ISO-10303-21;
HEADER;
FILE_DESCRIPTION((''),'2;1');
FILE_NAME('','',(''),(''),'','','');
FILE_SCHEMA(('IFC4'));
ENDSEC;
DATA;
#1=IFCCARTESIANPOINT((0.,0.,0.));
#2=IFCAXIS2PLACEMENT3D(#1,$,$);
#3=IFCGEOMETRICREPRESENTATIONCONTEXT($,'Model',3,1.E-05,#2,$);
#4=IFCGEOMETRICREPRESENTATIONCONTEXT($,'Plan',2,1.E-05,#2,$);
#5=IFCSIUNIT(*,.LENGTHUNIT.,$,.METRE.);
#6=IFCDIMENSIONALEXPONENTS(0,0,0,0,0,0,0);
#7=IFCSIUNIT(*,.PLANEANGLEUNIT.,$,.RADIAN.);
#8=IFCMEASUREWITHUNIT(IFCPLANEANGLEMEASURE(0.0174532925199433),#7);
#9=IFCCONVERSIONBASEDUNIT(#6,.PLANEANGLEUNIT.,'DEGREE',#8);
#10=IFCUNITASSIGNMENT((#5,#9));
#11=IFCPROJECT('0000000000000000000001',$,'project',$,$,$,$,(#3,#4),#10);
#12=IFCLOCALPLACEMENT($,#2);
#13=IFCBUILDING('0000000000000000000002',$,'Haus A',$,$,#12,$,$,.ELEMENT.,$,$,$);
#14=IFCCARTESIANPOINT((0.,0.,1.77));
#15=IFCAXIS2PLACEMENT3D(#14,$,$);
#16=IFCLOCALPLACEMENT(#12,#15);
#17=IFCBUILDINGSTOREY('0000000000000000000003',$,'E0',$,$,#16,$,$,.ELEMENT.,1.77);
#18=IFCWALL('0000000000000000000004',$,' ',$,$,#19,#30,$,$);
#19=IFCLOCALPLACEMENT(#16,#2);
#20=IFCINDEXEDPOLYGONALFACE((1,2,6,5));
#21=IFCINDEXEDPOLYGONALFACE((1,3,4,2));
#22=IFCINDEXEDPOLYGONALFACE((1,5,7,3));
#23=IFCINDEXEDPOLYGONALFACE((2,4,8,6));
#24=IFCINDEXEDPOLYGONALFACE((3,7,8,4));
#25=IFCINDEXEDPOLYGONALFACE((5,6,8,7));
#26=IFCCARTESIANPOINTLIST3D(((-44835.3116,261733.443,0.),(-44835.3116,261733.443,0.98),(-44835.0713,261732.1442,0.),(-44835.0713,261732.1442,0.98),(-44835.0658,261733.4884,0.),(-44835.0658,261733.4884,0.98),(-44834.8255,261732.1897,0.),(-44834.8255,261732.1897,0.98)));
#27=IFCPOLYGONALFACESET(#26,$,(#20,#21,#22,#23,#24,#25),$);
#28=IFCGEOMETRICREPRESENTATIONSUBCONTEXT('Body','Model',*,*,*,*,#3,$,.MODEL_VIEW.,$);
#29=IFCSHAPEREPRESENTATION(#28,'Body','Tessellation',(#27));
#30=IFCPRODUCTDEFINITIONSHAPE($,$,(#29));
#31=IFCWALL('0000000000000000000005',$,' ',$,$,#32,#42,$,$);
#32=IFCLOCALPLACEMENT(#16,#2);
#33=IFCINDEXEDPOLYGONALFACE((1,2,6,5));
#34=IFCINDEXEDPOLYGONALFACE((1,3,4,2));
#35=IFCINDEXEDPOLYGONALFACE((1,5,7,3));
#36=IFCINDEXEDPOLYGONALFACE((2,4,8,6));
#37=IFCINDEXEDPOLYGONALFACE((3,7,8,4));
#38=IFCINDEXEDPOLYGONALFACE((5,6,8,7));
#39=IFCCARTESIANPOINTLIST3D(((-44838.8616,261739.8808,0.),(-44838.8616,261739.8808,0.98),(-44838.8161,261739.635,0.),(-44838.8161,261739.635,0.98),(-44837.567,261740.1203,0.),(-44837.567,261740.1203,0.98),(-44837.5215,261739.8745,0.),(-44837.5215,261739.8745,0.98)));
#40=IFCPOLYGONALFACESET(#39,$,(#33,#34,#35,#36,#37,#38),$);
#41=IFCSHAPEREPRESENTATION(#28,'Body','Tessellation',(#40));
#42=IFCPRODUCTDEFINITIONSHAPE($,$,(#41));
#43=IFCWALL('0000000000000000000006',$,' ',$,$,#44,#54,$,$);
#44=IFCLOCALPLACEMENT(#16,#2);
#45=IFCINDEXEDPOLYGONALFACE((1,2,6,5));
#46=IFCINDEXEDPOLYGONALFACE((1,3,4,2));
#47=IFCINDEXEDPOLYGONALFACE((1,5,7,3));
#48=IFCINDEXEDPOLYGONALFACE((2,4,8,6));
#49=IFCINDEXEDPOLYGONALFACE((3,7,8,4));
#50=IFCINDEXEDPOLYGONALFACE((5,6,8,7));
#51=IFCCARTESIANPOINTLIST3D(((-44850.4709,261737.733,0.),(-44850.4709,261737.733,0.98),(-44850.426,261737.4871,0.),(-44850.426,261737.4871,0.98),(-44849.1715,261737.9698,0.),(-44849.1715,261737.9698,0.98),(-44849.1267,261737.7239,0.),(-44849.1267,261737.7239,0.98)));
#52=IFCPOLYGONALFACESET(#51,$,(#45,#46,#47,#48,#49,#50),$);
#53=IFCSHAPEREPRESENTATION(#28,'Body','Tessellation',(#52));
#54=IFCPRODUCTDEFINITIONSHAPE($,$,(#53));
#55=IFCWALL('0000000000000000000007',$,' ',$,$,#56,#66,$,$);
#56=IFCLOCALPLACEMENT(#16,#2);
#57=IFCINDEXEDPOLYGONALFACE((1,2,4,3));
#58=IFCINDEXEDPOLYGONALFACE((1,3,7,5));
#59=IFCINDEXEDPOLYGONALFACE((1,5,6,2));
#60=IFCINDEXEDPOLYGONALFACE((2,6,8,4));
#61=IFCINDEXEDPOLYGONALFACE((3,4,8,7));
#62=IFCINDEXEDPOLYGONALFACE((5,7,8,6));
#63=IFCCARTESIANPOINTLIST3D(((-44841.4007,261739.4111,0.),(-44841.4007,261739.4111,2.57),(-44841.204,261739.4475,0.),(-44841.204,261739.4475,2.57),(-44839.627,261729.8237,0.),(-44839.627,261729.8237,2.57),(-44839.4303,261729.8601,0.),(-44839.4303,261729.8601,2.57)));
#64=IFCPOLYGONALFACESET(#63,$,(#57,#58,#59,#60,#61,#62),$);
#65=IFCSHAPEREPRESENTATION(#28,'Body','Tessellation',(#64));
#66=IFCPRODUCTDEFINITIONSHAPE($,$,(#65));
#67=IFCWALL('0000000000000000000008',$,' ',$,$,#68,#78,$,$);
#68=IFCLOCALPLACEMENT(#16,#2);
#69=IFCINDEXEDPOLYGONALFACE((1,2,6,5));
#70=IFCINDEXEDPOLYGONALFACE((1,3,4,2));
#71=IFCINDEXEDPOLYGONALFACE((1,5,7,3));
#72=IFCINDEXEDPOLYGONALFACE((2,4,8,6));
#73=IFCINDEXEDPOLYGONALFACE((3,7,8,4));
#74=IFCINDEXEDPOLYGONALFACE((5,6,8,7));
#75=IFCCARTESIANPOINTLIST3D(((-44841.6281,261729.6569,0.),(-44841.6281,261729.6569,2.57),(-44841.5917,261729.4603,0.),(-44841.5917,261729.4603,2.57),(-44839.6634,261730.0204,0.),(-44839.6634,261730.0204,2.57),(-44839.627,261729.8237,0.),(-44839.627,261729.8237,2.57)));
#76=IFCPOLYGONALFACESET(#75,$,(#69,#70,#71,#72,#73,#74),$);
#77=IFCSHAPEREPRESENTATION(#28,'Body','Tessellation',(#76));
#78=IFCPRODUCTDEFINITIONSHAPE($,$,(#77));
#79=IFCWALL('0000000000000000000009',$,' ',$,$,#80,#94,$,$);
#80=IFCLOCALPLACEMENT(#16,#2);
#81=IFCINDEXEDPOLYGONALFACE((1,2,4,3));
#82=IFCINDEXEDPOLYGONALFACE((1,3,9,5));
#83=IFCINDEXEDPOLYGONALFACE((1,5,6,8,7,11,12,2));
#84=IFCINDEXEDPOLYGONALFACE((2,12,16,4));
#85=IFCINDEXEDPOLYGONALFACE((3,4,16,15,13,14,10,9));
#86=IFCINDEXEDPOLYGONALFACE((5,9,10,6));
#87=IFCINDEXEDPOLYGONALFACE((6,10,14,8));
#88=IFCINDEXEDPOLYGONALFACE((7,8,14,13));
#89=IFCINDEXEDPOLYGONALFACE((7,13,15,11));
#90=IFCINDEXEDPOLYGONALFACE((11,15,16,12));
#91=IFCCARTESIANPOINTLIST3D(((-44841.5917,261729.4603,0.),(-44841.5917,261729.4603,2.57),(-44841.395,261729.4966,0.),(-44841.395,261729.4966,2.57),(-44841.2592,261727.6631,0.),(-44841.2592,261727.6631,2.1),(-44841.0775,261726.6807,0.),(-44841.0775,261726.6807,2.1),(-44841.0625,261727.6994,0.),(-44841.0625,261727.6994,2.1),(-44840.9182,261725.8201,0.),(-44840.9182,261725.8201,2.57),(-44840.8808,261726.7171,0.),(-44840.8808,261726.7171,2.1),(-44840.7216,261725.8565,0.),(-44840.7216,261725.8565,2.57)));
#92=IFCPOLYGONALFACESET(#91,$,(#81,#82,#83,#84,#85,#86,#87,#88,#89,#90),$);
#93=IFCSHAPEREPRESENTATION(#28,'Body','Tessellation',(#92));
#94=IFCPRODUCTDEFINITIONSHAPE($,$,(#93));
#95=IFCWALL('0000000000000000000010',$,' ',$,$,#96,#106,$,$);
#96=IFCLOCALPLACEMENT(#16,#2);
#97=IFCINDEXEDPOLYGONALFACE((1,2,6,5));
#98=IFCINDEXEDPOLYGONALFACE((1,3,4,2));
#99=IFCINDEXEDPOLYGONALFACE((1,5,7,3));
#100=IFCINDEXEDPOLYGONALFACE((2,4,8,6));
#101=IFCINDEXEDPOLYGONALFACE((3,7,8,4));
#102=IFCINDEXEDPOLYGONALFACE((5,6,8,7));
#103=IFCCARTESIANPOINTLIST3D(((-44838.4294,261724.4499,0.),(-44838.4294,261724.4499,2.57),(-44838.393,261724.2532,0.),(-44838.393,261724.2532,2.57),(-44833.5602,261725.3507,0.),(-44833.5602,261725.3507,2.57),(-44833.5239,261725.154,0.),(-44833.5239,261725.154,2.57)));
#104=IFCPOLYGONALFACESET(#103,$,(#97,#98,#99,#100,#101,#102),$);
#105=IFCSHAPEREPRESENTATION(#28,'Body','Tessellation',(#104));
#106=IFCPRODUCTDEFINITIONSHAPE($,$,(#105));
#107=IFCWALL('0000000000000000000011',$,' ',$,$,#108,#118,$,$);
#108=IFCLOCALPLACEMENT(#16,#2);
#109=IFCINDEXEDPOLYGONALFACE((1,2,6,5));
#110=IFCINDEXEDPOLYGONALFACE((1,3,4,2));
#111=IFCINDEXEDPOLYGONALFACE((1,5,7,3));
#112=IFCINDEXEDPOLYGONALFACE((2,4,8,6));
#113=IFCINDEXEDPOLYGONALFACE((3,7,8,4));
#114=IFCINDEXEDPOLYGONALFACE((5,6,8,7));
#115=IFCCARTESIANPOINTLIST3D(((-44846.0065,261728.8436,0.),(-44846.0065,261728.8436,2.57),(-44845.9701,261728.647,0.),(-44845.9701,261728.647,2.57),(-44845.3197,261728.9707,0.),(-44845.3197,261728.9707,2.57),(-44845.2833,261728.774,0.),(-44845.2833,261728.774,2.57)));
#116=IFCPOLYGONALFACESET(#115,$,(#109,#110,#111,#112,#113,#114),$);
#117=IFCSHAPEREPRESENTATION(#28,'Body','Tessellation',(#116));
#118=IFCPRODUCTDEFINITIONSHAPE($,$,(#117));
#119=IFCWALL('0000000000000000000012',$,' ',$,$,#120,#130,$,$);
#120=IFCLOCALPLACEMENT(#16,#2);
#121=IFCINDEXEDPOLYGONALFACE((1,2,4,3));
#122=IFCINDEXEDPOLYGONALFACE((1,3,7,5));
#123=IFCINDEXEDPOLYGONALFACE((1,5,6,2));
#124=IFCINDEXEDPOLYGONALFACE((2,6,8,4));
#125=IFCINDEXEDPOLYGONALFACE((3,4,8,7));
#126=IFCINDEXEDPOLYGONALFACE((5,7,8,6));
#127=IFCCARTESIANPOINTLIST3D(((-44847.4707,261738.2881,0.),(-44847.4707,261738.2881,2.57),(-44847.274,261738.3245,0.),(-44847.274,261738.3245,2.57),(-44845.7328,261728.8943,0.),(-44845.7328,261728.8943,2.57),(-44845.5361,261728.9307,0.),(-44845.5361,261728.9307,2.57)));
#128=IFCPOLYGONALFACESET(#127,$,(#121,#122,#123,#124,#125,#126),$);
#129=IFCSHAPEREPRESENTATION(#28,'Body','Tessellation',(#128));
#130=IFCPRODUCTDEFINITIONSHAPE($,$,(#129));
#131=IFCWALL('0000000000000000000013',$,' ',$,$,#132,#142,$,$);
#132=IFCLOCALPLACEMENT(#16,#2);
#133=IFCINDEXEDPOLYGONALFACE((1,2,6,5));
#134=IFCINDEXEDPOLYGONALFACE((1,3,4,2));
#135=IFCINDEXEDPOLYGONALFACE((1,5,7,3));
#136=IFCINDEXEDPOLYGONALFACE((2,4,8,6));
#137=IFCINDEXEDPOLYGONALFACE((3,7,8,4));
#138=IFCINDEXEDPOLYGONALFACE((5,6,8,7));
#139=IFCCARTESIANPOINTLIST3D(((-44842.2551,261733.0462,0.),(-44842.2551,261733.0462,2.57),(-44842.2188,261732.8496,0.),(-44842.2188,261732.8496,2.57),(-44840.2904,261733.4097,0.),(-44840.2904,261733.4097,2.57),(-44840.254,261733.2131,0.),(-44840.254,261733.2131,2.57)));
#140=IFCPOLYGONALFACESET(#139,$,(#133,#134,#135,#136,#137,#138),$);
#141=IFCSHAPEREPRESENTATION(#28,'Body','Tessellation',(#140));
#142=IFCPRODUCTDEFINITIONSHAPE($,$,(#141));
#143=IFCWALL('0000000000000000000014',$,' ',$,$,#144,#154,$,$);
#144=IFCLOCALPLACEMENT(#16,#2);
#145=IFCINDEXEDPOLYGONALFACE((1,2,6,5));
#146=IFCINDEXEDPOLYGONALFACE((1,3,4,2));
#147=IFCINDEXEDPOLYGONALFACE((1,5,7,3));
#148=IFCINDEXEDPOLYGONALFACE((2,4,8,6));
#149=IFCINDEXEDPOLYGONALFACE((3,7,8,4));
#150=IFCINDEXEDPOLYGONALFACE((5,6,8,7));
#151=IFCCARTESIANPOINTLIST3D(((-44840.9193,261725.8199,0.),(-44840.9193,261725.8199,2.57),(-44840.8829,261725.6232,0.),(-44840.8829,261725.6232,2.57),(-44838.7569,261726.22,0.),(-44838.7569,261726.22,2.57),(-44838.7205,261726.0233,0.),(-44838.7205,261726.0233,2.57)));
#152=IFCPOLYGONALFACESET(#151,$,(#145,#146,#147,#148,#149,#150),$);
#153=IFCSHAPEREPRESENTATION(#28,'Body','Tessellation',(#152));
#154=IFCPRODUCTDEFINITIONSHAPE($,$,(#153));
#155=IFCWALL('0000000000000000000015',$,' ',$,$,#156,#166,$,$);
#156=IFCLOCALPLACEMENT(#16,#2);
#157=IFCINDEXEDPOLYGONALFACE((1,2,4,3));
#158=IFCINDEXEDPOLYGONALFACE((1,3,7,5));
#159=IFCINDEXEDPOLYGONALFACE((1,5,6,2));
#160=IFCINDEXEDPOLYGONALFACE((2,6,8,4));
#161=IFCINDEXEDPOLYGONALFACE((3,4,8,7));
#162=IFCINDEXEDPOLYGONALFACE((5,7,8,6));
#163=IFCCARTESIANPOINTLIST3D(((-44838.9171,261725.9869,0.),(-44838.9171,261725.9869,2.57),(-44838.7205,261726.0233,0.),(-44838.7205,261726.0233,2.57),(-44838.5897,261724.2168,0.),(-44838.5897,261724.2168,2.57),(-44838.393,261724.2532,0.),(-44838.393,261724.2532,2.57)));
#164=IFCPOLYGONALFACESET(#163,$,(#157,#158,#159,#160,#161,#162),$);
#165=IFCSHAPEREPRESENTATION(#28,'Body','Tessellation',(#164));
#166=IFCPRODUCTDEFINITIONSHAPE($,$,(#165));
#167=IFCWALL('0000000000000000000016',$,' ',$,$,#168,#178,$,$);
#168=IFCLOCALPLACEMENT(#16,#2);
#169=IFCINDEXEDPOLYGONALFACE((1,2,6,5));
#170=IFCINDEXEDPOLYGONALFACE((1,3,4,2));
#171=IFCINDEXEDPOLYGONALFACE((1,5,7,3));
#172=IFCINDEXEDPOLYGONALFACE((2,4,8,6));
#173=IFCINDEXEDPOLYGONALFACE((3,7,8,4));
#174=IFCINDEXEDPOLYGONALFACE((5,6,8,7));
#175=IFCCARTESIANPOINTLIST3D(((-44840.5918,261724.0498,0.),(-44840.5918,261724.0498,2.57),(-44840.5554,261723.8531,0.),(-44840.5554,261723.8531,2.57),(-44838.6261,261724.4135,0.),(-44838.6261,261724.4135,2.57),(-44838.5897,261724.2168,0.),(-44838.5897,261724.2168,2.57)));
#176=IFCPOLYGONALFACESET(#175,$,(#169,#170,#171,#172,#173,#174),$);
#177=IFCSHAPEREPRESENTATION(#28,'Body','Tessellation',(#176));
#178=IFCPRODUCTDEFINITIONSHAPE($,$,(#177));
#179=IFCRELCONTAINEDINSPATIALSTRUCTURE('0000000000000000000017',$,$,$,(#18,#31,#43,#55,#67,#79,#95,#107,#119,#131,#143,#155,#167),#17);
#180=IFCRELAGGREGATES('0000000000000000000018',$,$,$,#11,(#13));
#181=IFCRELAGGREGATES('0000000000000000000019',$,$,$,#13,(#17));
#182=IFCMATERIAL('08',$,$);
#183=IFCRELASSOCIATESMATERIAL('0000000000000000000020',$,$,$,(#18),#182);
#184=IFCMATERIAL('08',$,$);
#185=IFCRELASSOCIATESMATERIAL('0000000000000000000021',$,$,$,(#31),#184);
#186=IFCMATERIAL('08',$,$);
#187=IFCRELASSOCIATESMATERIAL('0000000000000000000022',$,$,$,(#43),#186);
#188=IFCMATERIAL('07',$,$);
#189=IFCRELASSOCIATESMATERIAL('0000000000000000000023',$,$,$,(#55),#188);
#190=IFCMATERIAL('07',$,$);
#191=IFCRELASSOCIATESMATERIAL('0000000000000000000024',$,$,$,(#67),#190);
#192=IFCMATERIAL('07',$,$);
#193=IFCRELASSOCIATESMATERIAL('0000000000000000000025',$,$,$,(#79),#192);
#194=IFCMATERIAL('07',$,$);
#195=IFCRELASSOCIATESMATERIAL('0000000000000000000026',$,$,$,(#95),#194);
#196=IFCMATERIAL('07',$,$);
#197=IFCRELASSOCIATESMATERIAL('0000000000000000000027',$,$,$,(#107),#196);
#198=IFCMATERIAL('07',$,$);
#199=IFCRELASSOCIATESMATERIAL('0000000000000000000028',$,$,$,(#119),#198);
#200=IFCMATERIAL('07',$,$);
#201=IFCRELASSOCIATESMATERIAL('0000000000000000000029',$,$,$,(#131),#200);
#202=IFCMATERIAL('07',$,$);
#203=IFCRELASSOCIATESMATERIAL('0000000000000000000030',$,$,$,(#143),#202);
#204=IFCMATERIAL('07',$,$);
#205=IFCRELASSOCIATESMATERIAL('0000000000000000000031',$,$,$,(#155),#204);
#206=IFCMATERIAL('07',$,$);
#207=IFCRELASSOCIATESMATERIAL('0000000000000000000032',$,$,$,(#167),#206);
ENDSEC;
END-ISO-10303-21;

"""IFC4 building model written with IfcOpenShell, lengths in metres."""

from ifc_helpers import new_model, entity, si_unit, converted_unit, frame, frame_2d, origin, origin_with_axes, place, context, subcontext, project, spatial, polyline, rectangle, outline, extrude, material, element, save


model = new_model("IFC4")

# Units and contexts
model_context = context("Model", 3, precision=1e-05, world=origin())
plan_context = context("Plan", 2, precision=1e-05, world=origin())
body_context = subcontext(model_context, "Body", "Model", "MODEL_VIEW")
ifc_project = project(units=[si_unit("LENGTHUNIT", "METRE"), converted_unit("PLANEANGLEUNIT", "DEGREE", entity("IfcPlaneAngleMeasure", 0.0174532925199433), si_unit("PLANEANGLEUNIT", "RADIAN"), dimensions=[0, 0, 0, 0, 0, 0, 0])], contexts=[model_context, plan_context])

# Building, storey
building_placement = place(None, origin())
building = spatial("IfcBuilding", under=ifc_project, at=building_placement, Name="Haus A", CompositionType="ELEMENT")
storey_placement = place(building_placement, frame((0.0, 0.0, 1.77)))
storey = spatial("IfcBuildingStorey", under=building, at=storey_placement, Name="E0", CompositionType="ELEMENT", Elevation=1.77)

# Walls
ifc_material_1 = material(Name="08")
wall_1_placement = place(storey_placement, frame((-44834.8255, 261732.1897, 0.0), z_axis=(0.0, 0.0, 1.0), x_axis=(-0.18192, 0.983313, 0.0)))
element("IfcWall", 1, at=wall_1_placement, inside=storey, material=ifc_material_1, Name=" ", context=body_context, shape_type="SweptSolid", body=[
    extrude(rectangle(XDim=1.3207, YDim=0.25, at=frame_2d((0.6604, 0.125), x_axis=(1.0, 0.0))), origin_with_axes(), (0.0, 0.0, 1.0), 0.98),
])
ifc_material_2 = material(Name="08")
wall_2_placement = place(storey_placement, frame((-44837.567, 261740.1203, 0.0), z_axis=(0.0, 0.0, 1.0), x_axis=(-0.983313, -0.18192, 0.0)))
element("IfcWall", 2, at=wall_2_placement, inside=storey, material=ifc_material_2, Name=" ", context=body_context, shape_type="SweptSolid", body=[
    extrude(rectangle(XDim=1.3165, YDim=0.25, at=frame_2d((0.6583, 0.125), x_axis=(1.0, 0.0))), origin_with_axes(), (0.0, 0.0, 1.0), 0.98),
])
ifc_material_3 = material(Name="08")
wall_3_placement = place(storey_placement, frame((-44849.1715, 261737.9698, 0.0), z_axis=(0.0, 0.0, 1.0), x_axis=(-0.983796, -0.17929, 0.0)))
element("IfcWall", 3, at=wall_3_placement, inside=storey, material=ifc_material_3, Name=" ", context=body_context, shape_type="SweptSolid", body=[
    extrude(rectangle(XDim=1.3208, YDim=0.25, at=frame_2d((0.6604, 0.125), x_axis=(1.0, 0.0))), origin_with_axes(), (0.0, 0.0, 1.0), 0.98),
])
ifc_material_4 = material(Name="07")
wall_4_placement = place(storey_placement, frame((-44841.4007, 261739.4111, 0.0), z_axis=(0.0, 0.0, 1.0), x_axis=(0.18192, -0.983313, 0.0)))
element("IfcWall", 4, at=wall_4_placement, inside=storey, material=ifc_material_4, Name=" ", context=body_context, shape_type="SweptSolid", body=[
    extrude(rectangle(XDim=9.75, YDim=0.2, at=frame_2d((4.875, 0.1), x_axis=(1.0, 0.0))), origin_with_axes(), (0.0, 0.0, 1.0), 2.57),
])
ifc_material_5 = material(Name="07")
wall_5_placement = place(storey_placement, frame((-44839.6634, 261730.0204, 0.0), z_axis=(0.0, 0.0, 1.0), x_axis=(-0.983313, -0.18192, 0.0)))
element("IfcWall", 5, at=wall_5_placement, inside=storey, material=ifc_material_5, Name=" ", context=body_context, shape_type="SweptSolid", body=[
    extrude(rectangle(XDim=1.9981, YDim=0.2, at=frame_2d((0.999, 0.1), x_axis=(1.0, 0.0))), origin_with_axes(), (0.0, 0.0, 1.0), 2.57),
])

# Wall, opening
ifc_material_6 = material(Name="07")
wall_6_placement = place(storey_placement, frame((-44841.5917, 261729.4603, 0.0), z_axis=(0.0, 0.0, 1.0), x_axis=(0.18192, -0.983313, 0.0)))
wall_6 = element("IfcWall", 6, at=wall_6_placement, inside=storey, material=ifc_material_6, Name=" ", context=body_context, shape_type="SweptSolid", body=[
    extrude(rectangle(XDim=3.7019, YDim=0.2, at=frame_2d((1.851, 0.1), x_axis=(1.0, 0.0))), origin_with_axes(), (0.0, 0.0, 1.0), 2.57),
])
opening_placement = place(wall_6_placement, frame((2.8267, 0.2, 0.0), z_axis=(0.0, -1.0, 0.0), x_axis=(0.0, 0.0, 1.0)))
element("IfcOpeningElement", 7, at=opening_placement, cuts=wall_6, ObjectType="Opening", context=body_context, shape_type="SweptSolid", body=[
    extrude(outline(polyline([(0.0, 0.999), (2.1, 0.999), (2.1, 0.0), (0.0, 0.0), (0.0, 0.999)])), origin_with_axes(), (0.0, 0.0, 1.0), 0.2),
])

# Walls
ifc_material_7 = material(Name="07")
wall_7_placement = place(storey_placement, frame((-44833.5602, 261725.3507, 0.0), z_axis=(0.0, 0.0, 1.0), x_axis=(-0.983313, -0.18192, 0.0)))
element("IfcWall", 8, at=wall_7_placement, inside=storey, material=ifc_material_7, Name=" ", context=body_context, shape_type="SweptSolid", body=[
    extrude(rectangle(XDim=4.9518, YDim=0.2, at=frame_2d((2.4759, 0.1), x_axis=(1.0, 0.0))), origin_with_axes(), (0.0, 0.0, 1.0), 2.57),
])
ifc_material_8 = material(Name="07")
wall_8_placement = place(storey_placement, frame((-44845.9701, 261728.647, 0.0), z_axis=(0.0, 0.0, 1.0), x_axis=(0.983313, 0.18192, 0.0)))
element("IfcWall", 9, at=wall_8_placement, inside=storey, material=ifc_material_8, Name=" ", context=body_context, shape_type="SweptSolid", body=[
    extrude(rectangle(XDim=0.6985, YDim=0.2, at=frame_2d((0.3492, 0.1), x_axis=(1.0, 0.0))), origin_with_axes(), (0.0, 0.0, 1.0), 2.57),
])
ifc_material_9 = material(Name="07")
wall_9_placement = place(storey_placement, frame((-44845.5361, 261728.9307, 0.0), z_axis=(0.0, 0.0, 1.0), x_axis=(-0.18192, 0.983313, 0.0)))
element("IfcWall", 10, at=wall_9_placement, inside=storey, material=ifc_material_9, Name=" ", context=body_context, shape_type="SweptSolid", body=[
    extrude(rectangle(XDim=9.5532, YDim=0.2, at=frame_2d((4.7766, 0.1), x_axis=(1.0, 0.0))), origin_with_axes(), (0.0, 0.0, 1.0), 2.57),
])
ifc_material_10 = material(Name="07")
wall_10_placement = place(storey_placement, frame((-44842.2188, 261732.8496, 0.0), z_axis=(0.0, 0.0, 1.0), x_axis=(0.983313, 0.18192, 0.0)))
element("IfcWall", 11, at=wall_10_placement, inside=storey, material=ifc_material_10, Name=" ", context=body_context, shape_type="SweptSolid", body=[
    extrude(rectangle(XDim=1.9981, YDim=0.2, at=frame_2d((0.999, 0.1), x_axis=(1.0, 0.0))), origin_with_axes(), (0.0, 0.0, 1.0), 2.57),
])
ifc_material_11 = material(Name="07")
wall_11_placement = place(storey_placement, frame((-44840.8829, 261725.6232, 0.0), z_axis=(0.0, 0.0, 1.0), x_axis=(0.983313, 0.18192, 0.0)))
element("IfcWall", 12, at=wall_11_placement, inside=storey, material=ifc_material_11, Name=" ", context=body_context, shape_type="SweptSolid", body=[
    extrude(rectangle(XDim=2.1991, YDim=0.2, at=frame_2d((1.0995, 0.1), x_axis=(1.0, 0.0))), origin_with_axes(), (0.0, 0.0, 1.0), 2.57),
])
ifc_material_12 = material(Name="07")
wall_12_placement = place(storey_placement, frame((-44838.9171, 261725.9869, 0.0), z_axis=(0.0, 0.0, 1.0), x_axis=(0.18192, -0.983313, 0.0)))
element("IfcWall", 13, at=wall_12_placement, inside=storey, material=ifc_material_12, Name=" ", context=body_context, shape_type="SweptSolid", body=[
    extrude(rectangle(XDim=1.8001, YDim=0.2, at=frame_2d((0.9001, 0.1), x_axis=(1.0, 0.0))), origin_with_axes(), (0.0, 0.0, 1.0), 2.57),
])
ifc_material_13 = material(Name="07")
wall_13_placement = place(storey_placement, frame((-44838.6261, 261724.4135, 0.0), z_axis=(0.0, 0.0, 1.0), x_axis=(-0.983313, -0.18192, 0.0)))
element("IfcWall", 14, at=wall_13_placement, inside=storey, material=ifc_material_13, Name=" ", context=body_context, shape_type="SweptSolid", body=[
    extrude(rectangle(XDim=1.9991, YDim=0.2, at=frame_2d((0.9995, 0.1), x_axis=(1.0, 0.0))), origin_with_axes(), (0.0, 0.0, 1.0), 2.57),
])

save(model, "model.ifc")
